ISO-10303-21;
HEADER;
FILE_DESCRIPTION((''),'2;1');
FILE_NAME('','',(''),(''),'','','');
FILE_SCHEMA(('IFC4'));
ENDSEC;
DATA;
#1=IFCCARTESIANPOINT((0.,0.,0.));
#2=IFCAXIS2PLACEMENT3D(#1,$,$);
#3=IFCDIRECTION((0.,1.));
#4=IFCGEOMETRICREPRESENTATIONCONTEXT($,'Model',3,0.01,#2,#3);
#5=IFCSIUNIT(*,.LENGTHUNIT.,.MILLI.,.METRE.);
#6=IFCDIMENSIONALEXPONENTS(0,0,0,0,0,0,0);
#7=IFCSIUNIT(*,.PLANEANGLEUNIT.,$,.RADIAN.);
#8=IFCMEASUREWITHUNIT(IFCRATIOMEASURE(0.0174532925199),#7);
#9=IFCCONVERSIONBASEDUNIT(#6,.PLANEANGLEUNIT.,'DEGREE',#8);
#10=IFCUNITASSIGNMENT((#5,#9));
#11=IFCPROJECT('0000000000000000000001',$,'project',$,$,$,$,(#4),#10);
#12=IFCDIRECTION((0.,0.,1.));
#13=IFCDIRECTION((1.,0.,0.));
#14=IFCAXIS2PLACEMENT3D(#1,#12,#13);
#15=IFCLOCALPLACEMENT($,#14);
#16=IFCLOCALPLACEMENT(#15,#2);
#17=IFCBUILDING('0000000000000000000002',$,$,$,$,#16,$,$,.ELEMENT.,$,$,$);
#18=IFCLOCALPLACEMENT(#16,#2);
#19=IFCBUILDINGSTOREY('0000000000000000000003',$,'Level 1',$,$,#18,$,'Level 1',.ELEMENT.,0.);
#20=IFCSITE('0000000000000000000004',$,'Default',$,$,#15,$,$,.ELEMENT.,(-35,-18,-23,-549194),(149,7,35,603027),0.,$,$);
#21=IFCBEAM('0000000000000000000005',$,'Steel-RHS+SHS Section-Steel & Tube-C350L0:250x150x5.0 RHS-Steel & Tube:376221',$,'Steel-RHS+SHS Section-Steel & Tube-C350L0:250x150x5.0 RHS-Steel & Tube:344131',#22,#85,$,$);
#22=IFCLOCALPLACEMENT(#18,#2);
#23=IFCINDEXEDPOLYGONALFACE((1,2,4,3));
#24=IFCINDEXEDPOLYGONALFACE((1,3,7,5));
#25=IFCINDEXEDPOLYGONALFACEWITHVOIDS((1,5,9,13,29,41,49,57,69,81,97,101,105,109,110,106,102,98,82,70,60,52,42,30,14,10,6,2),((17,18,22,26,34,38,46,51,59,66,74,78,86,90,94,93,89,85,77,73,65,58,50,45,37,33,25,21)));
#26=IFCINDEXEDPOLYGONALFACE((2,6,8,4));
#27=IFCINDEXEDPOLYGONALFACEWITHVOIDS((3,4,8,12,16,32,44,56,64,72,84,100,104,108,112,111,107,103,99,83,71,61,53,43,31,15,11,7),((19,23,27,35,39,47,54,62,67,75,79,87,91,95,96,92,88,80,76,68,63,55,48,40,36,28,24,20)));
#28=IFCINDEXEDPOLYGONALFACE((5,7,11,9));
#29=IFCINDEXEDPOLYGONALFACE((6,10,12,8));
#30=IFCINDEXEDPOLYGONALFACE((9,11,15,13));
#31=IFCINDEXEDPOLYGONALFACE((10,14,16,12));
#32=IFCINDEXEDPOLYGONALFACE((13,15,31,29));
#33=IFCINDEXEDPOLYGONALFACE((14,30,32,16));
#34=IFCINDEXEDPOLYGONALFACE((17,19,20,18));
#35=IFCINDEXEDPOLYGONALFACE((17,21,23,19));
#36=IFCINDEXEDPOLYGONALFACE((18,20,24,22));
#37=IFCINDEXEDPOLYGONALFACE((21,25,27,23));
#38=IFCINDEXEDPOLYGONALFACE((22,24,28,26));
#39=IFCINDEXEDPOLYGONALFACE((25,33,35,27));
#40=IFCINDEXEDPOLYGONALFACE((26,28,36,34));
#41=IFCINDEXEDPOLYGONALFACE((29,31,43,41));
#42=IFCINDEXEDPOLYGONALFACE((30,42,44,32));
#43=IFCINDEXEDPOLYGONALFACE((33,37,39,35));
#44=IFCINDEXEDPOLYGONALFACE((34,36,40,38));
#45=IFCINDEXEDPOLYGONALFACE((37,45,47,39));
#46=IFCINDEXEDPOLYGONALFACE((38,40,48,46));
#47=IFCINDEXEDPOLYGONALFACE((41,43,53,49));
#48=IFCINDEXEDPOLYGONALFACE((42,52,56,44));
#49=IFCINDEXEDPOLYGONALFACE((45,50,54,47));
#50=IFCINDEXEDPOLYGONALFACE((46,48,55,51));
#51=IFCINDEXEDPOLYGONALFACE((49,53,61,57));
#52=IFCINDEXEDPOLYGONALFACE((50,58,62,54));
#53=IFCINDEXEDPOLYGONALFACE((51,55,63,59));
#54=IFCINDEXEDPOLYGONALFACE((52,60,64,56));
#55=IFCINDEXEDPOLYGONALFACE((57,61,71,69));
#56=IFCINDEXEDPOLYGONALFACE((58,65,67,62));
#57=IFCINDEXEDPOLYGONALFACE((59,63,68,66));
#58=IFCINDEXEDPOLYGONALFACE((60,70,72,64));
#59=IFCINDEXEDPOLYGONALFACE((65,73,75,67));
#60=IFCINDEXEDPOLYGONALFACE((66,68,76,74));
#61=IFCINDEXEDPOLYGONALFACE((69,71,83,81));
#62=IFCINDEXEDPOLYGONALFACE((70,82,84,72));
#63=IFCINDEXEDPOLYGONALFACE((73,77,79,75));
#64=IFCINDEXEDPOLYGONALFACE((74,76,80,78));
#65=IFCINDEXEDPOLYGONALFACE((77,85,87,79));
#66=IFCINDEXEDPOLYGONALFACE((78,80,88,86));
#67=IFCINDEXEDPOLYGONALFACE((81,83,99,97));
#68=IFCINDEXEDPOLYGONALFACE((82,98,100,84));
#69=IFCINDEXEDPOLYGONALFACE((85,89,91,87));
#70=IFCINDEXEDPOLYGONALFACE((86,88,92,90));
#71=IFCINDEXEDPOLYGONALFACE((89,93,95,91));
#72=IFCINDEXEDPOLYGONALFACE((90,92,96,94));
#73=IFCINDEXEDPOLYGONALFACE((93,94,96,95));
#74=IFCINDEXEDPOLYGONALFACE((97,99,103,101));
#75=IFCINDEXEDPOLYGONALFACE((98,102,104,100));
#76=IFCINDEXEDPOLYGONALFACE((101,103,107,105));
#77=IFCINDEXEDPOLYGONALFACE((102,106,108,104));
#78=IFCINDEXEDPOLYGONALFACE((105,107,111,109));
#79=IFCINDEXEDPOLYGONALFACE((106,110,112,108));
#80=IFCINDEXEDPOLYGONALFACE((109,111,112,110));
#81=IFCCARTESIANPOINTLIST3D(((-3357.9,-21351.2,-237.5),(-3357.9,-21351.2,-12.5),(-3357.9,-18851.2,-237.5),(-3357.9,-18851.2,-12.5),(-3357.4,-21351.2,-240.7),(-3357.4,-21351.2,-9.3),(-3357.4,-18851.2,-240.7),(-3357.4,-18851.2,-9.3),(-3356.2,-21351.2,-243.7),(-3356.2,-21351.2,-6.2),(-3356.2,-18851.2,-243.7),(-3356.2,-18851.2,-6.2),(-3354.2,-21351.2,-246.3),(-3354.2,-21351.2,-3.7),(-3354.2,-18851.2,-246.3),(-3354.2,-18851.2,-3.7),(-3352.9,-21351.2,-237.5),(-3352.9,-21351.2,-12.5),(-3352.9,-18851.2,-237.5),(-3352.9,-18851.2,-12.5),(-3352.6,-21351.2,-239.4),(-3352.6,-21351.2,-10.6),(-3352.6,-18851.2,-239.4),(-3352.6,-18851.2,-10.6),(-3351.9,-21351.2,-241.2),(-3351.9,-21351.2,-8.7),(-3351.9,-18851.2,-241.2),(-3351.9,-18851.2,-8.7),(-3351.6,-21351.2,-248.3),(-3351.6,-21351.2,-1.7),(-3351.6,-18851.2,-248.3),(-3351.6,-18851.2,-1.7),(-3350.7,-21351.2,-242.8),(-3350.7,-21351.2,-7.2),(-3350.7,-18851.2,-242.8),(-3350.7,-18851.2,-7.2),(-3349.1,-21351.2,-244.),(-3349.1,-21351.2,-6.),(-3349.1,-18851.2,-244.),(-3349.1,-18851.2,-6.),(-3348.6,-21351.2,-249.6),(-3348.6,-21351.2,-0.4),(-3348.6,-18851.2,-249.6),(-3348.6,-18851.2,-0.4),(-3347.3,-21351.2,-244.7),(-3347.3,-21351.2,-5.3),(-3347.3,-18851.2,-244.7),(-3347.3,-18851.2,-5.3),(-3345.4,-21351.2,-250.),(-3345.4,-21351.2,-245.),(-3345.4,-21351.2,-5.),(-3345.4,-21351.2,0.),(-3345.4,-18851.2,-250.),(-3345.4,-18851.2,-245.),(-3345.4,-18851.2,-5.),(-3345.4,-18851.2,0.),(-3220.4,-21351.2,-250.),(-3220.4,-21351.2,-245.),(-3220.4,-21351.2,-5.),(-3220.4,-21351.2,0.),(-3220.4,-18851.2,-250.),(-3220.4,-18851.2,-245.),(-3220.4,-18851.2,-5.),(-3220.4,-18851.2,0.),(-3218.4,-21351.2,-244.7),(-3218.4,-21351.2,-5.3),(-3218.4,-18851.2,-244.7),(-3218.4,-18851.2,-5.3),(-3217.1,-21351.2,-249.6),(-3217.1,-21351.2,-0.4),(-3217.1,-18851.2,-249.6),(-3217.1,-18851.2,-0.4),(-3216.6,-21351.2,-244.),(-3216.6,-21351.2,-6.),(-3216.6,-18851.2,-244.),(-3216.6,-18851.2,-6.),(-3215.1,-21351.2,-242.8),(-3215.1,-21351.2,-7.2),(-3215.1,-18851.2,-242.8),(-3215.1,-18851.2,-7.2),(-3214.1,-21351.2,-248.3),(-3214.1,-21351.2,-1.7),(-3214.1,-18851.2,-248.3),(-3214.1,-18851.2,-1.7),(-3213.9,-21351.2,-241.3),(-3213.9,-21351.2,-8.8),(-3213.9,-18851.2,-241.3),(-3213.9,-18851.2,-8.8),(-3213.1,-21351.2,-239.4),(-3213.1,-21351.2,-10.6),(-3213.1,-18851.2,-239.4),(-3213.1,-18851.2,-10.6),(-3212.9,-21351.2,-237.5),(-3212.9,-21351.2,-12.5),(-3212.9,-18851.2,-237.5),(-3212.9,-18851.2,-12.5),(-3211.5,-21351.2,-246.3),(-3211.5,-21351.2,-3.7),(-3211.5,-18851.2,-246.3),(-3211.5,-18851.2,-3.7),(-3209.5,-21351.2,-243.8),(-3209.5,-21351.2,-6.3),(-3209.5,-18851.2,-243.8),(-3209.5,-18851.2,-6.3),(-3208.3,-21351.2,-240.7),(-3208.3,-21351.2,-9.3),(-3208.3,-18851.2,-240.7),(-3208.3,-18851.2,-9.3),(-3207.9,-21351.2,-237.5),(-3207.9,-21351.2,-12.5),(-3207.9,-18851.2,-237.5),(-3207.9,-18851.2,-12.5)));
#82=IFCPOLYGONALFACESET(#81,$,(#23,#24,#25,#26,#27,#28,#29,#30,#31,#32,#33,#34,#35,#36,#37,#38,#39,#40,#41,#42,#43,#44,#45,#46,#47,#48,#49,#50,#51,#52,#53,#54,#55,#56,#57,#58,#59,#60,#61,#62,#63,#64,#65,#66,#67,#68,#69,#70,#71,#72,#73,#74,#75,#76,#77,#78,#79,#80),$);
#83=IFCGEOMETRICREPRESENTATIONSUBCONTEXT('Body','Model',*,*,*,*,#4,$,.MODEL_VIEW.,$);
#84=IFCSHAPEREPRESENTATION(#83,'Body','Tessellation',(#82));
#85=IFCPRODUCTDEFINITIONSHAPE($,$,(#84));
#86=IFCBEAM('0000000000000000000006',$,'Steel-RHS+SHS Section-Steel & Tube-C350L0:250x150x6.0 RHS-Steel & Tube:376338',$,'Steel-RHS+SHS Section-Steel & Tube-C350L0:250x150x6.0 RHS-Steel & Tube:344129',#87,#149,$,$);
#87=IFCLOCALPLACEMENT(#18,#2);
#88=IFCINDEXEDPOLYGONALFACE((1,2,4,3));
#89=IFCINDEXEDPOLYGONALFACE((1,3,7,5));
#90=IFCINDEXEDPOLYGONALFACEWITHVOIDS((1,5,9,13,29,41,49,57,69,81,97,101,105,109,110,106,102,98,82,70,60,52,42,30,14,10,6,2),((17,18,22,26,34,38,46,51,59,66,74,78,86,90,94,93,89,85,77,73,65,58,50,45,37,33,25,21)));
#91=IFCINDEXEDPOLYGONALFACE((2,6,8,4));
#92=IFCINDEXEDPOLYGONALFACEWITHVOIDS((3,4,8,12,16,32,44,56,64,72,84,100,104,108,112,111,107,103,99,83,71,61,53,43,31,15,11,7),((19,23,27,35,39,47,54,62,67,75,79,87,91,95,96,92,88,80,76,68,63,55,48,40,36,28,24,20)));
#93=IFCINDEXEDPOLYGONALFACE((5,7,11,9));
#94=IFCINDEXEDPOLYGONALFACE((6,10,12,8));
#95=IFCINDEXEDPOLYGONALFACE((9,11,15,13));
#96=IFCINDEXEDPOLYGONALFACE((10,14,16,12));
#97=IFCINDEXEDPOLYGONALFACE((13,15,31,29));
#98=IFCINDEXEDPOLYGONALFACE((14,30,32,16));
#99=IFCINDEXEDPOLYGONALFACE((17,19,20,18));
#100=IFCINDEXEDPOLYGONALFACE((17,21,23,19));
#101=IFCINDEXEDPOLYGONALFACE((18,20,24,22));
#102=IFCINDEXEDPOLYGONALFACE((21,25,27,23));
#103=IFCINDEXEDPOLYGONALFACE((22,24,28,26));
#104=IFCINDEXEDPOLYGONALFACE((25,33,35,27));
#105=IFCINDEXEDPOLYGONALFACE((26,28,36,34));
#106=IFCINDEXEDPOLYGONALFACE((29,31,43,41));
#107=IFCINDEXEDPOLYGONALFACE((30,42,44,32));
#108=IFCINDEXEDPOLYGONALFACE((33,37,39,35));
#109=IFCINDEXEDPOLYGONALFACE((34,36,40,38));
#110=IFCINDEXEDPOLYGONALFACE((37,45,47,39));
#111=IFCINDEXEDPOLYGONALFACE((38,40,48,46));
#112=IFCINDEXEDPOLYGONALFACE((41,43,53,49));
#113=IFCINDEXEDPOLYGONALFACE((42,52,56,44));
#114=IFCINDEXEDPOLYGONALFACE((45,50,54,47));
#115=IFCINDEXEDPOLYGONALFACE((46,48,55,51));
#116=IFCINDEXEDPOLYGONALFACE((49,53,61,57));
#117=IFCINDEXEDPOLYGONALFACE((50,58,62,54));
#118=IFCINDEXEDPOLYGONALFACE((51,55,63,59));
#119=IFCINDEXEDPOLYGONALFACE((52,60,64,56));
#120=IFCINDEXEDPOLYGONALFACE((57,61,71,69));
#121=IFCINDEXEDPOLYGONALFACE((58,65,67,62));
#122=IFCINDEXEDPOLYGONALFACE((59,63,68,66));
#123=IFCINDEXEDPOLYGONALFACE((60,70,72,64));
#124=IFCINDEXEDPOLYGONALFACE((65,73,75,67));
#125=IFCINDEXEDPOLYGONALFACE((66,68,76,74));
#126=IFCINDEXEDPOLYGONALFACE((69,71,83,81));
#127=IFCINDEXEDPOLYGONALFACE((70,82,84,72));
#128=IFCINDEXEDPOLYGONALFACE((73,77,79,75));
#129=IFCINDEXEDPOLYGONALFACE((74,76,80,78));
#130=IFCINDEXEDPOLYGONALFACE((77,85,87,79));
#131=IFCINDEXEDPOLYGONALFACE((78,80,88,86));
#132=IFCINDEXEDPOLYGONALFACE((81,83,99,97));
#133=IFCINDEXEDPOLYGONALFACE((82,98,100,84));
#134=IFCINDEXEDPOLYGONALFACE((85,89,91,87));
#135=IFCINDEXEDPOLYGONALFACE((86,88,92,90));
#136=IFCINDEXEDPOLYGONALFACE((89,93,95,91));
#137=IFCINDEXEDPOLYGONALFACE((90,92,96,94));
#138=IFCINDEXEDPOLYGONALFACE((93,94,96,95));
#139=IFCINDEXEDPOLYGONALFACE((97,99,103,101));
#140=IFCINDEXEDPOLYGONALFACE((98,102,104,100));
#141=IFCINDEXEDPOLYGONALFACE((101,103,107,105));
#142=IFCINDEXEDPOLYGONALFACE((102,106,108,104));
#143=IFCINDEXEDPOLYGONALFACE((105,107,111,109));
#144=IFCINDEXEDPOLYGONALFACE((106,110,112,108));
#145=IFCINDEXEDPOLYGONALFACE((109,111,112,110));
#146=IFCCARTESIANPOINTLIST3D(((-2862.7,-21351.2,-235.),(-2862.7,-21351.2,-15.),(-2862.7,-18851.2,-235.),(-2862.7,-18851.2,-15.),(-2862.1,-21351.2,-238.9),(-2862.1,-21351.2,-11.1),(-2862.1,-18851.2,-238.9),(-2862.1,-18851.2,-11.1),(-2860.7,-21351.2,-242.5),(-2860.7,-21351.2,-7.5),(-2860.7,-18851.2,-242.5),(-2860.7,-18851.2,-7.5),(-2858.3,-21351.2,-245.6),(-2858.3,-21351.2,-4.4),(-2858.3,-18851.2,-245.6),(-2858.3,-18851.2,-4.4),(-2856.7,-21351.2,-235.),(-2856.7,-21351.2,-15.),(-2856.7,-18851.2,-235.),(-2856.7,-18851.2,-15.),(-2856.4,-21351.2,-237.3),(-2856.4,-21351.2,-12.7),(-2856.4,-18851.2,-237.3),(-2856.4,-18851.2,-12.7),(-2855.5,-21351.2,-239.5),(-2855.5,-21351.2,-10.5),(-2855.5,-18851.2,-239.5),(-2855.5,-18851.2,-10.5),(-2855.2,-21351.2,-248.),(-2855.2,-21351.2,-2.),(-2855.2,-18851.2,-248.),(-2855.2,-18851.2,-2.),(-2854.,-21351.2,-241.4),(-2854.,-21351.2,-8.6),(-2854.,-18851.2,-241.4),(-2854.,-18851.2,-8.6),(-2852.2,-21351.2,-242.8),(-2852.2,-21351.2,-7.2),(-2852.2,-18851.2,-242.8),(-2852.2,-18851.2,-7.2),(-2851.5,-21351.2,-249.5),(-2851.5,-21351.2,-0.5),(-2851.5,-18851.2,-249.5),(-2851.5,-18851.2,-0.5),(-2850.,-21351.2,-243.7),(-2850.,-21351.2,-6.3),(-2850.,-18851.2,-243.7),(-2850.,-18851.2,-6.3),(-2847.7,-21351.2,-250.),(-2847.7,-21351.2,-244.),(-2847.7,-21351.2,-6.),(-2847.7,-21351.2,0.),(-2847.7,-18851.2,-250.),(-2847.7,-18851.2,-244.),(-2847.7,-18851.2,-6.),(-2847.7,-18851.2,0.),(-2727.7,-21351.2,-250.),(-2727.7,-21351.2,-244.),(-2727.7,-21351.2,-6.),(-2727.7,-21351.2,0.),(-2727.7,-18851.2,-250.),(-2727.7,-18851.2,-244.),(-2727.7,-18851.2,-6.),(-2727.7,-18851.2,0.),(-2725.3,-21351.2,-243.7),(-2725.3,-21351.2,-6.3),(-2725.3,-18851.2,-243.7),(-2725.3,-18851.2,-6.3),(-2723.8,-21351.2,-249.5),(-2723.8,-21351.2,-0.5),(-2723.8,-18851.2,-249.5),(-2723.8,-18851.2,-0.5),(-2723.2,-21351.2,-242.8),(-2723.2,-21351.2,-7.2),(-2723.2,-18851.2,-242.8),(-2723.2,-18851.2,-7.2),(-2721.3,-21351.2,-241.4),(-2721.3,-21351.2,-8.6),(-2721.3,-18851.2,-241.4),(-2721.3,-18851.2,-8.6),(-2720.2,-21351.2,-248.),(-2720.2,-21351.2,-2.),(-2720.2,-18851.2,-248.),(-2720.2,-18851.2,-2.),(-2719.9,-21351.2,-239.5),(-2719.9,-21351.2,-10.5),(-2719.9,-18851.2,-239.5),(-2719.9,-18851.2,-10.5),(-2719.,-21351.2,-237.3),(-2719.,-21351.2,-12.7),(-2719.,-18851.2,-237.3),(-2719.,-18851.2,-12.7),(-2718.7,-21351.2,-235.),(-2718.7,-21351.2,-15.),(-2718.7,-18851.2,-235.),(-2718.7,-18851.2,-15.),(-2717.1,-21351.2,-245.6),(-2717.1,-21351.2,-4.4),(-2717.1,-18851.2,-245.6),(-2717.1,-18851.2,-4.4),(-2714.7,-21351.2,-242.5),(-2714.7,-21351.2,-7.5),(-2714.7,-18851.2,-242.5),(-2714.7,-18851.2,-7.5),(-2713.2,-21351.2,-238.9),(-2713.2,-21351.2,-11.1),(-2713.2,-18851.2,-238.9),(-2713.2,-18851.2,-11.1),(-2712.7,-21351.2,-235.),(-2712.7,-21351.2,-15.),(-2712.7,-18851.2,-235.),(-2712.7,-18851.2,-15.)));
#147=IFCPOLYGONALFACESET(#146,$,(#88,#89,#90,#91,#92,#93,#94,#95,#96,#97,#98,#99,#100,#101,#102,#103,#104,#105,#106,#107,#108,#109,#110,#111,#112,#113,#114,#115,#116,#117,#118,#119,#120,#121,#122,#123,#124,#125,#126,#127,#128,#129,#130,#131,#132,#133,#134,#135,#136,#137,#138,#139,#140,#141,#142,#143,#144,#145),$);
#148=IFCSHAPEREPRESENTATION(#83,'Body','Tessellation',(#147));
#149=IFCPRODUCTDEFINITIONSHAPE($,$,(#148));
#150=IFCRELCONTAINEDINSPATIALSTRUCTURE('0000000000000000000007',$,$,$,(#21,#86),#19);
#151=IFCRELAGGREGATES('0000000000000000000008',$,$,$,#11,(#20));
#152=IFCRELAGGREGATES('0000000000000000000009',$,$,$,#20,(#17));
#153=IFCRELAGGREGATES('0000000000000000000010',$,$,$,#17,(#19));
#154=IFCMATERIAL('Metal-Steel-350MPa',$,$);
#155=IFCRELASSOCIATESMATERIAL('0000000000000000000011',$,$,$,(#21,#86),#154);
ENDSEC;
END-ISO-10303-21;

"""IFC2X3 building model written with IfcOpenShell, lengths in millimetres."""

from ifc_helpers import new_model, entity, si_unit, converted_unit, direction, frame, frame_2d, origin, origin_with_axes, place, context, subcontext, project, spatial, polyline, circle_curve, parameter, trimmed, segment, composite_curve, outline, extrude, material, element, save


model = new_model("IFC2X3")

# Units and contexts
model_context = context("Model", 3, precision=0.01, world=origin(), true_north=direction((0.0, 1.0)))
body_context = subcontext(model_context, "Body", "Model", "MODEL_VIEW")
ifc_project = project(units=[si_unit("LENGTHUNIT", "METRE", prefix="MILLI"), converted_unit("PLANEANGLEUNIT", "DEGREE", entity("IfcRatioMeasure", 0.0174532925199), si_unit("PLANEANGLEUNIT", "RADIAN"), dimensions=[0, 0, 0, 0, 0, 0, 0])], contexts=[model_context])

# Site, building, storey
site_placement = place(None, origin_with_axes())
site = spatial("IfcSite", under=ifc_project, at=site_placement, Name="Default", CompositionType="ELEMENT", RefLatitude=(-35, -18, -23, -549194), RefLongitude=(149, 7, 35, 603027), RefElevation=0.0)
building_placement = place(site_placement, origin())
building = spatial("IfcBuilding", under=site, at=building_placement, CompositionType="ELEMENT")
storey_placement = place(building_placement, origin())
storey = spatial("IfcBuildingStorey", under=building, at=storey_placement, Name="Level 1", LongName="Level 1", CompositionType="ELEMENT", Elevation=0.0)

# Beams
ifc_material = material(Name="Metal-Steel-350MPa")
beam_1_placement = place(storey_placement, frame((-3282.9, -18851.2, 0.0), z_axis=(0.0, 0.0, 1.0), x_axis=(0.0, -1.0, 0.0)))
element("IfcBeam", 1, at=beam_1_placement, inside=storey, material=ifc_material, Name="Steel-RHS+SHS Section-Steel & Tube-C350L0:250x150x5.0 RHS-Steel & Tube:376221", ObjectType="Steel-RHS+SHS Section-Steel & Tube-C350L0:250x150x5.0 RHS-Steel & Tube:344131", context=body_context, shape_type="SweptSolid", body=[
    extrude(outline(composite_curve([segment(trimmed(circle_curve(frame_2d((-62.5, -112.5), x_axis=(1.0, 0.0)), 12.5), [parameter(180.0)], [parameter(270.0)], True, "PARAMETER"), True, "CONTINUOUS"), segment(polyline([(-62.5, -125.0), (62.5, -125.0)]), True, "CONTINUOUS"), segment(trimmed(circle_curve(frame_2d((62.5, -112.5), x_axis=(1.0, 0.0)), 12.5), [parameter(270.0)], [parameter(0.0)], True, "PARAMETER"), True, "CONTINUOUS"), segment(polyline([(75.0, -112.5), (75.0, 112.5)]), True, "CONTINUOUS"), segment(trimmed(circle_curve(frame_2d((62.5, 112.5), x_axis=(1.0, 0.0)), 12.5), [parameter(0.0)], [parameter(90.0)], True, "PARAMETER"), True, "CONTINUOUS"), segment(polyline([(62.5, 125.0), (-62.5, 125.0)]), True, "CONTINUOUS"), segment(trimmed(circle_curve(frame_2d((-62.5, 112.5), x_axis=(1.0, 0.0)), 12.5), [parameter(90.0)], [parameter(180.0)], True, "PARAMETER"), True, "CONTINUOUS"), segment(polyline([(-75.0, 112.5), (-75.0, -112.5)]), True, "CONTINUOUS")], self_intersect=False), holes=[composite_curve([segment(polyline([(62.5, -120.0), (-62.5, -120.0)]), True, "CONTINUOUS"), segment(trimmed(circle_curve(frame_2d((-62.5, -112.5), x_axis=(1.0, 0.0)), 7.5), [parameter(180.0)], [parameter(270.0)], True, "PARAMETER"), False, "CONTINUOUS"), segment(polyline([(-70.0, -112.5), (-70.0, 112.5)]), True, "CONTINUOUS"), segment(trimmed(circle_curve(frame_2d((-62.5, 112.5), x_axis=(1.0, 0.0)), 7.5), [parameter(90.0)], [parameter(180.0)], True, "PARAMETER"), False, "CONTINUOUS"), segment(polyline([(-62.5, 120.0), (62.5, 120.0)]), True, "CONTINUOUS"), segment(trimmed(circle_curve(frame_2d((62.5, 112.5), x_axis=(1.0, 0.0)), 7.5), [parameter(360.0)], [parameter(90.0)], True, "PARAMETER"), False, "CONTINUOUS"), segment(polyline([(70.0, 112.5), (70.0, -112.5)]), True, "CONTINUOUS"), segment(trimmed(circle_curve(frame_2d((62.5, -112.5), x_axis=(1.0, 0.0)), 7.5), [parameter(270.0)], [parameter(0.0)], True, "PARAMETER"), False, "CONTINUOUS")], self_intersect=False)]), frame((0.0, 0.0, -125.0), z_axis=(1.0, 0.0, 0.0), x_axis=(0.0, -1.0, 0.0)), (0.0, 0.0, 1.0), 2500.0),
])
beam_2_placement = place(storey_placement, frame((-2787.7, -18851.2, 0.0), z_axis=(0.0, 0.0, 1.0), x_axis=(0.0, -1.0, 0.0)))
element("IfcBeam", 2, at=beam_2_placement, inside=storey, material=ifc_material, Name="Steel-RHS+SHS Section-Steel & Tube-C350L0:250x150x6.0 RHS-Steel & Tube:376338", ObjectType="Steel-RHS+SHS Section-Steel & Tube-C350L0:250x150x6.0 RHS-Steel & Tube:344129", context=body_context, shape_type="SweptSolid", body=[
    extrude(outline(composite_curve([segment(trimmed(circle_curve(frame_2d((-60.0, -110.0), x_axis=(1.0, 0.0)), 15.0), [parameter(180.0)], [parameter(270.0)], True, "PARAMETER"), True, "CONTINUOUS"), segment(polyline([(-60.0, -125.0), (60.0, -125.0)]), True, "CONTINUOUS"), segment(trimmed(circle_curve(frame_2d((60.0, -110.0), x_axis=(1.0, 0.0)), 15.0), [parameter(270.0)], [parameter(0.0)], True, "PARAMETER"), True, "CONTINUOUS"), segment(polyline([(75.0, -110.0), (75.0, 110.0)]), True, "CONTINUOUS"), segment(trimmed(circle_curve(frame_2d((60.0, 110.0), x_axis=(1.0, 0.0)), 15.0), [parameter(0.0)], [parameter(90.0)], True, "PARAMETER"), True, "CONTINUOUS"), segment(polyline([(60.0, 125.0), (-60.0, 125.0)]), True, "CONTINUOUS"), segment(trimmed(circle_curve(frame_2d((-60.0, 110.0), x_axis=(1.0, 0.0)), 15.0), [parameter(90.0)], [parameter(180.0)], True, "PARAMETER"), True, "CONTINUOUS"), segment(polyline([(-75.0, 110.0), (-75.0, -110.0)]), True, "CONTINUOUS")], self_intersect=False), holes=[composite_curve([segment(polyline([(60.0, -119.0), (-60.0, -119.0)]), True, "CONTINUOUS"), segment(trimmed(circle_curve(frame_2d((-60.0, -110.0), x_axis=(1.0, 0.0)), 9.0), [parameter(180.0)], [parameter(270.0)], True, "PARAMETER"), False, "CONTINUOUS"), segment(polyline([(-69.0, -110.0), (-69.0, 110.0)]), True, "CONTINUOUS"), segment(trimmed(circle_curve(frame_2d((-60.0, 110.0), x_axis=(1.0, 0.0)), 9.0), [parameter(90.0)], [parameter(180.0)], True, "PARAMETER"), False, "CONTINUOUS"), segment(polyline([(-60.0, 119.0), (60.0, 119.0)]), True, "CONTINUOUS"), segment(trimmed(circle_curve(frame_2d((60.0, 110.0), x_axis=(1.0, 0.0)), 9.0), [parameter(360.0)], [parameter(90.0)], True, "PARAMETER"), False, "CONTINUOUS"), segment(polyline([(69.0, 110.0), (69.0, -110.0)]), True, "CONTINUOUS"), segment(trimmed(circle_curve(frame_2d((60.0, -110.0), x_axis=(1.0, 0.0)), 9.0), [parameter(270.0)], [parameter(0.0)], True, "PARAMETER"), False, "CONTINUOUS")], self_intersect=False)]), frame((0.0, 0.0, -125.0), z_axis=(1.0, 0.0, 0.0), x_axis=(0.0, -1.0, 0.0)), (0.0, 0.0, 1.0), 2500.0),
])

save(model, "model.ifc")
